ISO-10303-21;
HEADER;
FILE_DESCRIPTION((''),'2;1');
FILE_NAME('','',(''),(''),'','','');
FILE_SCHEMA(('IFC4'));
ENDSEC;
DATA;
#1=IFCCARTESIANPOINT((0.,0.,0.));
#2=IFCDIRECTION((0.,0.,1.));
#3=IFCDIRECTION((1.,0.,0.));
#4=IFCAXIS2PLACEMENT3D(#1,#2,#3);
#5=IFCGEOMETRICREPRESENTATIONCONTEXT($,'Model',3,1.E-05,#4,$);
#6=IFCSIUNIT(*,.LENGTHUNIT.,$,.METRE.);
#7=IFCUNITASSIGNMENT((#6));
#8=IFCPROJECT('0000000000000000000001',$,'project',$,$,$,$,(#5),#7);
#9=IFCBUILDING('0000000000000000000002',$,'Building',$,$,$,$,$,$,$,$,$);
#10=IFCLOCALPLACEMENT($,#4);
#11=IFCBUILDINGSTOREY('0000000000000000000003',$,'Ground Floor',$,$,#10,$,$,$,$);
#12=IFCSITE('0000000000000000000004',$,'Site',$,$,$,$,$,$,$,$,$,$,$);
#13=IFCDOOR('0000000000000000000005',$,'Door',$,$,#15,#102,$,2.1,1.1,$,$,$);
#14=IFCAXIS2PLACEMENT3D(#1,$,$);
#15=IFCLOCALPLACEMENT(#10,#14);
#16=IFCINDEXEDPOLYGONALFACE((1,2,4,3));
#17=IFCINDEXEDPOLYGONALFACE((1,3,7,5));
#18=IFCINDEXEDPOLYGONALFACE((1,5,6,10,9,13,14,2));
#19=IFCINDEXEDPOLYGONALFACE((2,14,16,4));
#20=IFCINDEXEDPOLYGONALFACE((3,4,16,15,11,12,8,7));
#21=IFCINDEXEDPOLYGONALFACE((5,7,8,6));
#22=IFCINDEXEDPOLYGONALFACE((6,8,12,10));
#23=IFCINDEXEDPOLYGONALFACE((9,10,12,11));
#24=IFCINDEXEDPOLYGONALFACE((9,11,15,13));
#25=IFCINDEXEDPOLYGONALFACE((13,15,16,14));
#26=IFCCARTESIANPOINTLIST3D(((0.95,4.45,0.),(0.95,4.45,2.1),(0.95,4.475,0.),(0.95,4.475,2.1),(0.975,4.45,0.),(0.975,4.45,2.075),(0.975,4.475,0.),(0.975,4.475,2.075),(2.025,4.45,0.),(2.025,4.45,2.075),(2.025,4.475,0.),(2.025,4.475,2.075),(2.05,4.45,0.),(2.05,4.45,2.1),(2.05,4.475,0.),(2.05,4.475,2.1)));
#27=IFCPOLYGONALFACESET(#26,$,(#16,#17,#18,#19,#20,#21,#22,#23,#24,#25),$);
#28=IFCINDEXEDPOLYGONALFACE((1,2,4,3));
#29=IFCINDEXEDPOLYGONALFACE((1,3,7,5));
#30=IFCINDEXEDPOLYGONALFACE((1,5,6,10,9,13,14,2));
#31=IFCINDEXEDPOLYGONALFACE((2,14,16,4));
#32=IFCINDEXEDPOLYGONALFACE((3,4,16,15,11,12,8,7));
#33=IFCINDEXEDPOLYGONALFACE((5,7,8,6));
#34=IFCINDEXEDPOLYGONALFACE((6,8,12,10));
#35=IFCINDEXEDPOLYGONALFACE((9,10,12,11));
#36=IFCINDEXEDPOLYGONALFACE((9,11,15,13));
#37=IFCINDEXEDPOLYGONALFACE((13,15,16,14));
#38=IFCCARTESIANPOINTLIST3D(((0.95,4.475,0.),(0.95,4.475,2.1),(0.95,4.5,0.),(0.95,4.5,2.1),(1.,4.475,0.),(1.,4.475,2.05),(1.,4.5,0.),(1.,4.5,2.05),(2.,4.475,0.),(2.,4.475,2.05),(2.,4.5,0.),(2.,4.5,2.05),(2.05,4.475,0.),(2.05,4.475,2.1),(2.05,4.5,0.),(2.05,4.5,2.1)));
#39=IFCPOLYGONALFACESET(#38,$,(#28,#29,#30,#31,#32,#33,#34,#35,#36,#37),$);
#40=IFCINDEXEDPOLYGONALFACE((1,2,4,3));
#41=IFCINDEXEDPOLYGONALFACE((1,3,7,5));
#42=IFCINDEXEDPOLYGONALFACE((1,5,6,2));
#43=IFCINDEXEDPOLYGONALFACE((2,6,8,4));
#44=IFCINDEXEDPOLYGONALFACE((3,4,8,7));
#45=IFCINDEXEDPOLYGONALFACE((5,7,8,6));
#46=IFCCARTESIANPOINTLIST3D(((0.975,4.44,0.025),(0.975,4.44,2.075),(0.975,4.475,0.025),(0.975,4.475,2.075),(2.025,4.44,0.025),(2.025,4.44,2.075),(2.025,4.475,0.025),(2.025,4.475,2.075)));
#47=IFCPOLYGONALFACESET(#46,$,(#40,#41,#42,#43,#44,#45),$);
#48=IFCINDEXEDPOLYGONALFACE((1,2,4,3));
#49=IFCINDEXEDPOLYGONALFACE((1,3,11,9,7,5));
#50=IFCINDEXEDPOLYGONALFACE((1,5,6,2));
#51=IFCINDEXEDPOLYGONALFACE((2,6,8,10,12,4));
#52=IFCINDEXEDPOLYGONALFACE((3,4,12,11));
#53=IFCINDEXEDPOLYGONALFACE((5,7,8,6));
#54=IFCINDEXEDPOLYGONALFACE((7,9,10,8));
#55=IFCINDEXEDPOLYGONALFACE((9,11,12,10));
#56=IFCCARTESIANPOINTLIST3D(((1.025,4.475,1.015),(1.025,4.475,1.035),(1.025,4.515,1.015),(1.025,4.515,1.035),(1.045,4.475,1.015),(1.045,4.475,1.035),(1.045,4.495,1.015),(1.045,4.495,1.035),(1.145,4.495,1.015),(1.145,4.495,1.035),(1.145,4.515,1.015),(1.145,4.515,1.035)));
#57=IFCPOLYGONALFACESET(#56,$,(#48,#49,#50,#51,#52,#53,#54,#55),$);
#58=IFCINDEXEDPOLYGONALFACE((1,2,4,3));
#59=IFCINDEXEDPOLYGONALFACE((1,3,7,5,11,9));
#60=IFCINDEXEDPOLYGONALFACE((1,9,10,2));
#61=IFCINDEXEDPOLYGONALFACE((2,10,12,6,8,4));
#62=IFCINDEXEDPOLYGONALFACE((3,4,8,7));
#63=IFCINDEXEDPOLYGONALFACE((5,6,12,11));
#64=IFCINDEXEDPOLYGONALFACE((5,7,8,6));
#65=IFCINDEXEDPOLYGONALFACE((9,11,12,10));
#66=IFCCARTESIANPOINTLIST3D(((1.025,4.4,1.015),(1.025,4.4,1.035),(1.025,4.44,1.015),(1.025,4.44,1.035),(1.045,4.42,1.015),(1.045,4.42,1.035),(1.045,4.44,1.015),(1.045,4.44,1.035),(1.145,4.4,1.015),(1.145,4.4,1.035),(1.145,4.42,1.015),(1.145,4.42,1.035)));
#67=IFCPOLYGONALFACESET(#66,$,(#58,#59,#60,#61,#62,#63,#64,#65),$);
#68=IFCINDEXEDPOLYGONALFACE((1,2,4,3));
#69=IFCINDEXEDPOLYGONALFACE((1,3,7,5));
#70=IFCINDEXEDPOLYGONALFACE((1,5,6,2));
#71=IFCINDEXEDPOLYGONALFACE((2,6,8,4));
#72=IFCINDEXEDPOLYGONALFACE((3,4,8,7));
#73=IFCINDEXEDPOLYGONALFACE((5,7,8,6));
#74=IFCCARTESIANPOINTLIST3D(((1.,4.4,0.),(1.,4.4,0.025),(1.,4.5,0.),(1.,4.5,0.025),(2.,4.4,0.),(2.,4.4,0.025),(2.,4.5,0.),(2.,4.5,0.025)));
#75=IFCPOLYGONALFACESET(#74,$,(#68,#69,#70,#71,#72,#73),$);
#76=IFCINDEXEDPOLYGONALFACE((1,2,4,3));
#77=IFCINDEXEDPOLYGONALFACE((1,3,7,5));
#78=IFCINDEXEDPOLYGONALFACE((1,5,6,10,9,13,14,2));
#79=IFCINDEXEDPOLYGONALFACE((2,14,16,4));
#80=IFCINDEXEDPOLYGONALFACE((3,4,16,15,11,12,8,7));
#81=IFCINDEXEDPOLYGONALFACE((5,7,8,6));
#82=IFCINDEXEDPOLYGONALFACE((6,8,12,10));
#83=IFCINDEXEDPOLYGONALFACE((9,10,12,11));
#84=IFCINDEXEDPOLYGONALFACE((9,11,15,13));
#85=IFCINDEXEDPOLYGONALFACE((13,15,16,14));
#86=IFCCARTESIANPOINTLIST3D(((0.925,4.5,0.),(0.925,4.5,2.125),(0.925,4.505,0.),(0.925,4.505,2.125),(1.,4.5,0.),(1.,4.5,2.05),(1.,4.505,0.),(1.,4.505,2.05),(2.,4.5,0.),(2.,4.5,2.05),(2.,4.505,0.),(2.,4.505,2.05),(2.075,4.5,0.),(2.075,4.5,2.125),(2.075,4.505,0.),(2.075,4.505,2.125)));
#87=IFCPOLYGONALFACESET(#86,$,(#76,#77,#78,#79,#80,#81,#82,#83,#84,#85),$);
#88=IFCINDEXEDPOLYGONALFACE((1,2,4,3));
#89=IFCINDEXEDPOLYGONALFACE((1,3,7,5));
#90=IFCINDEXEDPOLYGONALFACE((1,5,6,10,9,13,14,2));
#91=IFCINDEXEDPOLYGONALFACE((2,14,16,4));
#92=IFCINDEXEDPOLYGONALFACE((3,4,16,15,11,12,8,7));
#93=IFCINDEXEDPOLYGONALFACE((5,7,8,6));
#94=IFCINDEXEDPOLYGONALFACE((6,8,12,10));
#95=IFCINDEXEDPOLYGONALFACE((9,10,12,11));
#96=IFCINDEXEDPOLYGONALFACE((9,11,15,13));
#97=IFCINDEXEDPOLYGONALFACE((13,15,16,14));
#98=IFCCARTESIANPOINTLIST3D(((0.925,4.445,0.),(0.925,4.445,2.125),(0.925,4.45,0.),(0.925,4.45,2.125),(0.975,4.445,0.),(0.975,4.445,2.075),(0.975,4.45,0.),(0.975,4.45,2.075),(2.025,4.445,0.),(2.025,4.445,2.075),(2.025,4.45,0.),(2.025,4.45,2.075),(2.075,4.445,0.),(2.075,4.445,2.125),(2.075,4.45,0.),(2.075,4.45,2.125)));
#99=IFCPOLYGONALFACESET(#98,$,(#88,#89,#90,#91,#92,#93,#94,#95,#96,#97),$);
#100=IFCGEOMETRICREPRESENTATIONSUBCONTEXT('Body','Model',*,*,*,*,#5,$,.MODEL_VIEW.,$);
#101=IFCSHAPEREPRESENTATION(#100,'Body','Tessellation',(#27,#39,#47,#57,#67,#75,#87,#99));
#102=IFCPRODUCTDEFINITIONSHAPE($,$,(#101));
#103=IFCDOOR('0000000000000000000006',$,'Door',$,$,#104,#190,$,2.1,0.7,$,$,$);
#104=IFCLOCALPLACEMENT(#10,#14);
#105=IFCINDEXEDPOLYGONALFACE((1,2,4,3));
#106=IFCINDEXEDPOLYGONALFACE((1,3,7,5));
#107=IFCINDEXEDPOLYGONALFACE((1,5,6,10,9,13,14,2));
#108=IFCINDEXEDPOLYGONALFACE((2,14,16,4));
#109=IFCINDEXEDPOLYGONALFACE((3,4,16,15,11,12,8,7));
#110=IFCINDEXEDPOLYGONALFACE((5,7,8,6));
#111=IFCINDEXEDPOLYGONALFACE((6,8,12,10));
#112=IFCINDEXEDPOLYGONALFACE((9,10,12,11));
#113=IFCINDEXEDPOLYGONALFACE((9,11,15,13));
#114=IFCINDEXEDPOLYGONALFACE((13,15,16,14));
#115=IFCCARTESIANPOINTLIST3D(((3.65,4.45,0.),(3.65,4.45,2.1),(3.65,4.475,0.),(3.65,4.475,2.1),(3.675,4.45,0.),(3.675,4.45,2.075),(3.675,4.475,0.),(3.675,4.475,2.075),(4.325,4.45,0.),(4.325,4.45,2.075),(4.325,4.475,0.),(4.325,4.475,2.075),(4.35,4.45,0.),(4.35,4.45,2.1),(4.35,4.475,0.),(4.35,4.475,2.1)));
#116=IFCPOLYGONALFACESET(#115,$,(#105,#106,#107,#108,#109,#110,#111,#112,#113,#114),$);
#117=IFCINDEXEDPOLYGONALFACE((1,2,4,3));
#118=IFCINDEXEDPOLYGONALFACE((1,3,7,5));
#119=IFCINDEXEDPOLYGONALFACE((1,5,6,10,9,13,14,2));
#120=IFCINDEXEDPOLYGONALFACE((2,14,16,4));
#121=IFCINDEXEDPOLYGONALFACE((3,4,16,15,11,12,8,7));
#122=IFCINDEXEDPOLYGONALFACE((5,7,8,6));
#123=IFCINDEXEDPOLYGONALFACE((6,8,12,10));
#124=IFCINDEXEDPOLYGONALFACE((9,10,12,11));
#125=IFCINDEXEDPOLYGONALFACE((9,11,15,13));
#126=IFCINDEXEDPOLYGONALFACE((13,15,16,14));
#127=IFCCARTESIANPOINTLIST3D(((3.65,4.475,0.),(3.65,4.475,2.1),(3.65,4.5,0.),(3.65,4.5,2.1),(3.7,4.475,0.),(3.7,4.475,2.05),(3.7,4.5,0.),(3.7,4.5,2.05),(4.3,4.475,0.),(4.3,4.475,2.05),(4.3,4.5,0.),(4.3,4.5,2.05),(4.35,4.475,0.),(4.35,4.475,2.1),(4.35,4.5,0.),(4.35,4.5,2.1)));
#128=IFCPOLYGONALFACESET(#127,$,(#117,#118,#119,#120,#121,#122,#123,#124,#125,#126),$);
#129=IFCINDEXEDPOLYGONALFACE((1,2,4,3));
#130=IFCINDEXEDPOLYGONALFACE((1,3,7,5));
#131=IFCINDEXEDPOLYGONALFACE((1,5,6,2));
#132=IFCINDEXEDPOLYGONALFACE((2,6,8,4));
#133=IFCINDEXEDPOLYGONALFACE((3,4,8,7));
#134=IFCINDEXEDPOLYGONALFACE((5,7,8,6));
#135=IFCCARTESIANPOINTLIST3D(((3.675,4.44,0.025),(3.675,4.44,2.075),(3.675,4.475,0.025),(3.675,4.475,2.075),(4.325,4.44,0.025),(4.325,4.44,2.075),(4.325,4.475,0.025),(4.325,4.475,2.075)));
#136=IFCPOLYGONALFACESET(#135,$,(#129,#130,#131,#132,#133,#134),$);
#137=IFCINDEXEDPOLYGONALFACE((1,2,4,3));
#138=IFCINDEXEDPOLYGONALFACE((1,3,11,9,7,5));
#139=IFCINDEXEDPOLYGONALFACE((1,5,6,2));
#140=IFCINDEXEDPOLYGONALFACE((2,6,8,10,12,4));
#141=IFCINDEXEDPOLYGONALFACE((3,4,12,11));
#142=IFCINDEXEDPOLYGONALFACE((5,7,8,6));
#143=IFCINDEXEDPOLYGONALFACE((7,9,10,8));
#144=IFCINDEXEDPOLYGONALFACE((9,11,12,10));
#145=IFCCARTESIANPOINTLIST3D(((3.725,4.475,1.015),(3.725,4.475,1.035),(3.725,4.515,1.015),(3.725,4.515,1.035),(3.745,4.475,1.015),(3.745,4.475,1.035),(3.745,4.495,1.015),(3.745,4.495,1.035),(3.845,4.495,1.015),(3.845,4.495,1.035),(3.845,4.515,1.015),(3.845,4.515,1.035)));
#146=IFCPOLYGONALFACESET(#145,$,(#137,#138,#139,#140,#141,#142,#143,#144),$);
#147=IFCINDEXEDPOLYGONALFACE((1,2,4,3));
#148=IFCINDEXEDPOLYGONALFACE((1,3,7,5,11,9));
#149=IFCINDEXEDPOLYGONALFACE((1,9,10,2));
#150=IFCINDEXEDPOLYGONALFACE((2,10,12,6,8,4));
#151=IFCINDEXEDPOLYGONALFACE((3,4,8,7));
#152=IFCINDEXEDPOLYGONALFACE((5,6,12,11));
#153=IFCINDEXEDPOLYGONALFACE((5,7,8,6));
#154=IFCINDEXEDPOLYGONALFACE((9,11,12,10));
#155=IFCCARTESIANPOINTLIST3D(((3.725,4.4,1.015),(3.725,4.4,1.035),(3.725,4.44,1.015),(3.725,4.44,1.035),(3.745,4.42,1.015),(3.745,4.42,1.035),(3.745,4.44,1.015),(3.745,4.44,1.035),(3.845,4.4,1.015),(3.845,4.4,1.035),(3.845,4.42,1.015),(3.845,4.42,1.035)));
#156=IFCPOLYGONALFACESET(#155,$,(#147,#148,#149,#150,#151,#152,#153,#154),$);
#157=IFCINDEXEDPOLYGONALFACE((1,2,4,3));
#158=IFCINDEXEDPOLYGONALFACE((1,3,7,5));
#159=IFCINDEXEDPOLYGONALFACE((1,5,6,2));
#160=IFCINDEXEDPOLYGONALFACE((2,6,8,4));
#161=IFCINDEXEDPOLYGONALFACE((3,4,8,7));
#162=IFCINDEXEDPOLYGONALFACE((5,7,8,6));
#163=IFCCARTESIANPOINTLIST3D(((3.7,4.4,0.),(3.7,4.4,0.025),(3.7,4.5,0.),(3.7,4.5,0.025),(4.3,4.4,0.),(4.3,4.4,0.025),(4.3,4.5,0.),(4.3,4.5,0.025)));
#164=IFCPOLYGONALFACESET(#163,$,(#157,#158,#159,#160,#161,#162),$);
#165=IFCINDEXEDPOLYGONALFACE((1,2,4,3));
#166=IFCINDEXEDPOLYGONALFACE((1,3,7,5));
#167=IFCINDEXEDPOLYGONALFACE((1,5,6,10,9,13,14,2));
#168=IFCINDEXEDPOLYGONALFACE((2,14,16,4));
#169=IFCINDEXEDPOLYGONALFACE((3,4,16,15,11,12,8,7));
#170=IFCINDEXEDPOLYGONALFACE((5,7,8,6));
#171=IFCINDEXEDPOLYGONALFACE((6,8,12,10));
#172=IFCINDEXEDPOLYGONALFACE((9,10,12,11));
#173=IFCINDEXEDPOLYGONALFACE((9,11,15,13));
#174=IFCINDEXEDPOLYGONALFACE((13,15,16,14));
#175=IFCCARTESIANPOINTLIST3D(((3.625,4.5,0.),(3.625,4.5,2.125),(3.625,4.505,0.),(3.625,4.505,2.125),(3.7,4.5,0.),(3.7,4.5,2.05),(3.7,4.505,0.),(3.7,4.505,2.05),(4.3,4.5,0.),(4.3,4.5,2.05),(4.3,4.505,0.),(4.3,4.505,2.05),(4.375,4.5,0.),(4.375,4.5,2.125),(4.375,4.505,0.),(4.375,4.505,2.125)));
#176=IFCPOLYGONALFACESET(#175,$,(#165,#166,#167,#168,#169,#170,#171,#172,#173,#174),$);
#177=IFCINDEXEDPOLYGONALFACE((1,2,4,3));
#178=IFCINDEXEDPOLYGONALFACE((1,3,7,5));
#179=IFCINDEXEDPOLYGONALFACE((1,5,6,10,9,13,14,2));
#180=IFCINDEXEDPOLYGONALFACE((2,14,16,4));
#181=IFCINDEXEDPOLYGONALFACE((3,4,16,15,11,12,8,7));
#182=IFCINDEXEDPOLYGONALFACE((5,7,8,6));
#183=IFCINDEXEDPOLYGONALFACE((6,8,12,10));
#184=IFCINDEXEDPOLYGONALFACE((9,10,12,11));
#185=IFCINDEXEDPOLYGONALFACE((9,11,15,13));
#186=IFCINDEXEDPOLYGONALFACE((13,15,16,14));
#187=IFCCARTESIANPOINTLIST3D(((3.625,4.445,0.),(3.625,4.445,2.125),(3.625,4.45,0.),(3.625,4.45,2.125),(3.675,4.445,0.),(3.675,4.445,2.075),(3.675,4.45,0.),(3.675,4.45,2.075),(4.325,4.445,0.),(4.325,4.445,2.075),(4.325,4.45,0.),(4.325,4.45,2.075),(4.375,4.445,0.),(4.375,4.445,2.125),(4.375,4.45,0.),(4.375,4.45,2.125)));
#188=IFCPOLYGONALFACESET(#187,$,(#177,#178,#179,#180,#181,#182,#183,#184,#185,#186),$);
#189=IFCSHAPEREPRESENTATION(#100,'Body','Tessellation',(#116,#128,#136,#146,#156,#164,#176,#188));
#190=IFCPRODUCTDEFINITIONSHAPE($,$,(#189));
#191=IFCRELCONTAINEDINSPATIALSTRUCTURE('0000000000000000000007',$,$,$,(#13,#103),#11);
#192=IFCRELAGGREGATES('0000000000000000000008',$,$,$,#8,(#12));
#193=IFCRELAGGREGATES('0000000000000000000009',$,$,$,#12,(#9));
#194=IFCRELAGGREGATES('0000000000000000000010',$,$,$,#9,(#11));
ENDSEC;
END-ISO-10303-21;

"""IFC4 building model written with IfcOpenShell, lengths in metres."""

from ifc_helpers import new_model, si_unit, frame, origin_with_axes, place, context, subcontext, project, spatial, line, indexed_curve, outline, extrude, element, save


model = new_model("IFC4")

# Units and contexts
model_context = context("Model", 3, precision=1e-05, world=origin_with_axes())
body_context = subcontext(model_context, "Body", "Model", "MODEL_VIEW")
ifc_project = project(units=[si_unit("LENGTHUNIT", "METRE")], contexts=[model_context])

# Site, building, storey
site = spatial("IfcSite", under=ifc_project, Name="Site")
building = spatial("IfcBuilding", under=site, Name="Building")
storey_placement = place(None, origin_with_axes())
storey = spatial("IfcBuildingStorey", under=building, at=storey_placement, Name="Ground Floor")

# Doors
door_1_placement = place(storey_placement, frame((2.05, 4.5, 0.0), z_axis=(0.0, 0.0, 1.0), x_axis=(-1.0, 0.0, 0.0)))
element("IfcDoor", 1, at=door_1_placement, inside=storey, Name="Door", OverallHeight=2.1, OverallWidth=1.1, context=body_context, shape_type="SweptSolid", body=[
    extrude(outline(indexed_curve([(0.0, 0.0), (0.0, 2.1), (1.1, 2.1), (1.1, 0.0), (1.075, 0.0), (1.075, 2.075), (0.025, 2.075), (0.025, 0.0)], segments=[line(1, 2, 3, 4, 5, 6, 7, 8, 1)])), frame((0.0, 0.025, 0.0), z_axis=(0.0, -1.0, 0.0), x_axis=(1.0, 0.0, 0.0)), (0.0, 0.0, -1.0), 0.025),
    extrude(outline(indexed_curve([(0.0, 0.0), (0.0, 2.1), (1.1, 2.1), (1.1, 0.0), (1.05, 0.0), (1.05, 2.05), (0.05, 2.05), (0.05, 0.0)], segments=[line(1, 2, 3, 4, 5, 6, 7, 8, 1)])), frame((0.0, 0.0, 0.0), z_axis=(0.0, -1.0, 0.0), x_axis=(1.0, 0.0, 0.0)), (0.0, 0.0, -1.0), 0.025),
    extrude(outline(indexed_curve([(0.0, 0.0), (1.05, 0.0), (1.05, 0.035), (0.0, 0.035)], segments=[line(1, 2, 3, 4, 1)])), frame((0.025, 0.025, 0.025), z_axis=(0.0, 0.0, 1.0), x_axis=(1.0, 0.0, 0.0)), (0.0, 0.0, 1.0), 2.05),
    extrude(outline(indexed_curve([(0.0, 0.0), (0.0, -0.04), (-0.12, -0.04), (-0.12, -0.02), (-0.02, -0.02), (-0.02, 0.0)], segments=[line(1, 2, 3, 4, 5, 6, 1)])), frame((1.025, 0.025, 1.015), z_axis=(0.0, 0.0, 1.0), x_axis=(1.0, 0.0, 0.0)), (0.0, 0.0, 1.0), 0.02),
    extrude(outline(indexed_curve([(0.0, 0.0), (0.0, 0.04), (-0.12, 0.04), (-0.12, 0.02), (-0.02, 0.02), (-0.02, 0.0)], segments=[line(1, 2, 3, 4, 5, 6, 1)])), frame((1.025, 0.06, 1.015), z_axis=(0.0, 0.0, 1.0), x_axis=(1.0, 0.0, 0.0)), (0.0, 0.0, 1.0), 0.02),
    extrude(outline(indexed_curve([(0.0, 0.0), (1.0, 0.0), (1.0, 0.1), (0.0, 0.1)], segments=[line(1, 2, 3, 4, 1)])), frame((0.05, 0.0, 0.0), z_axis=(0.0, 0.0, 1.0), x_axis=(1.0, 0.0, 0.0)), (0.0, 0.0, 1.0), 0.025),
    extrude(outline(indexed_curve([(0.0, 0.0), (0.0, 2.125), (1.15, 2.125), (1.15, 0.0), (1.075, 0.0), (1.075, 2.05), (0.075, 2.05), (0.075, 0.0)], segments=[line(1, 2, 3, 4, 5, 6, 7, 8, 1)])), frame((-0.025, -0.005, 0.0), z_axis=(0.0, -1.0, 0.0), x_axis=(1.0, 0.0, 0.0)), (0.0, 0.0, -1.0), 0.005),
    extrude(outline(indexed_curve([(0.0, 0.0), (0.0, 2.125), (1.15, 2.125), (1.15, 0.0), (1.1, 0.0), (1.1, 2.075), (0.05, 2.075), (0.05, 0.0)], segments=[line(1, 2, 3, 4, 5, 6, 7, 8, 1)])), frame((-0.025, 0.05, 0.0), z_axis=(0.0, -1.0, 0.0), x_axis=(1.0, 0.0, 0.0)), (0.0, 0.0, -1.0), 0.005),
])
door_2_placement = place(storey_placement, frame((4.35, 4.5, 0.0), z_axis=(0.0, 0.0, 1.0), x_axis=(-1.0, 0.0, 0.0)))
element("IfcDoor", 2, at=door_2_placement, inside=storey, Name="Door", OverallHeight=2.1, OverallWidth=0.7, context=body_context, shape_type="SweptSolid", body=[
    extrude(outline(indexed_curve([(0.0, 0.0), (0.0, 2.1), (0.7, 2.1), (0.7, 0.0), (0.675, 0.0), (0.675, 2.075), (0.025, 2.075), (0.025, 0.0)], segments=[line(1, 2, 3, 4, 5, 6, 7, 8, 1)])), frame((0.0, 0.025, 0.0), z_axis=(0.0, -1.0, 0.0), x_axis=(1.0, 0.0, 0.0)), (0.0, 0.0, -1.0), 0.025),
    extrude(outline(indexed_curve([(0.0, 0.0), (0.0, 2.1), (0.7, 2.1), (0.7, 0.0), (0.65, 0.0), (0.65, 2.05), (0.05, 2.05), (0.05, 0.0)], segments=[line(1, 2, 3, 4, 5, 6, 7, 8, 1)])), frame((0.0, 0.0, 0.0), z_axis=(0.0, -1.0, 0.0), x_axis=(1.0, 0.0, 0.0)), (0.0, 0.0, -1.0), 0.025),
    extrude(outline(indexed_curve([(0.0, 0.0), (0.65, 0.0), (0.65, 0.035), (0.0, 0.035)], segments=[line(1, 2, 3, 4, 1)])), frame((0.025, 0.025, 0.025), z_axis=(0.0, 0.0, 1.0), x_axis=(1.0, 0.0, 0.0)), (0.0, 0.0, 1.0), 2.05),
    extrude(outline(indexed_curve([(0.0, 0.0), (0.0, -0.04), (-0.12, -0.04), (-0.12, -0.02), (-0.02, -0.02), (-0.02, 0.0)], segments=[line(1, 2, 3, 4, 5, 6, 1)])), frame((0.625, 0.025, 1.015), z_axis=(0.0, 0.0, 1.0), x_axis=(1.0, 0.0, 0.0)), (0.0, 0.0, 1.0), 0.02),
    extrude(outline(indexed_curve([(0.0, 0.0), (0.0, 0.04), (-0.12, 0.04), (-0.12, 0.02), (-0.02, 0.02), (-0.02, 0.0)], segments=[line(1, 2, 3, 4, 5, 6, 1)])), frame((0.625, 0.06, 1.015), z_axis=(0.0, 0.0, 1.0), x_axis=(1.0, 0.0, 0.0)), (0.0, 0.0, 1.0), 0.02),
    extrude(outline(indexed_curve([(0.0, 0.0), (0.6, 0.0), (0.6, 0.1), (0.0, 0.1)], segments=[line(1, 2, 3, 4, 1)])), frame((0.05, 0.0, 0.0), z_axis=(0.0, 0.0, 1.0), x_axis=(1.0, 0.0, 0.0)), (0.0, 0.0, 1.0), 0.025),
    extrude(outline(indexed_curve([(0.0, 0.0), (0.0, 2.125), (0.75, 2.125), (0.75, 0.0), (0.675, 0.0), (0.675, 2.05), (0.075, 2.05), (0.075, 0.0)], segments=[line(1, 2, 3, 4, 5, 6, 7, 8, 1)])), frame((-0.025, -0.005, 0.0), z_axis=(0.0, -1.0, 0.0), x_axis=(1.0, 0.0, 0.0)), (0.0, 0.0, -1.0), 0.005),
    extrude(outline(indexed_curve([(0.0, 0.0), (0.0, 2.125), (0.75, 2.125), (0.75, 0.0), (0.7, 0.0), (0.7, 2.075), (0.05, 2.075), (0.05, 0.0)], segments=[line(1, 2, 3, 4, 5, 6, 7, 8, 1)])), frame((-0.025, 0.05, 0.0), z_axis=(0.0, -1.0, 0.0), x_axis=(1.0, 0.0, 0.0)), (0.0, 0.0, -1.0), 0.005),
])

save(model, "model.ifc")
